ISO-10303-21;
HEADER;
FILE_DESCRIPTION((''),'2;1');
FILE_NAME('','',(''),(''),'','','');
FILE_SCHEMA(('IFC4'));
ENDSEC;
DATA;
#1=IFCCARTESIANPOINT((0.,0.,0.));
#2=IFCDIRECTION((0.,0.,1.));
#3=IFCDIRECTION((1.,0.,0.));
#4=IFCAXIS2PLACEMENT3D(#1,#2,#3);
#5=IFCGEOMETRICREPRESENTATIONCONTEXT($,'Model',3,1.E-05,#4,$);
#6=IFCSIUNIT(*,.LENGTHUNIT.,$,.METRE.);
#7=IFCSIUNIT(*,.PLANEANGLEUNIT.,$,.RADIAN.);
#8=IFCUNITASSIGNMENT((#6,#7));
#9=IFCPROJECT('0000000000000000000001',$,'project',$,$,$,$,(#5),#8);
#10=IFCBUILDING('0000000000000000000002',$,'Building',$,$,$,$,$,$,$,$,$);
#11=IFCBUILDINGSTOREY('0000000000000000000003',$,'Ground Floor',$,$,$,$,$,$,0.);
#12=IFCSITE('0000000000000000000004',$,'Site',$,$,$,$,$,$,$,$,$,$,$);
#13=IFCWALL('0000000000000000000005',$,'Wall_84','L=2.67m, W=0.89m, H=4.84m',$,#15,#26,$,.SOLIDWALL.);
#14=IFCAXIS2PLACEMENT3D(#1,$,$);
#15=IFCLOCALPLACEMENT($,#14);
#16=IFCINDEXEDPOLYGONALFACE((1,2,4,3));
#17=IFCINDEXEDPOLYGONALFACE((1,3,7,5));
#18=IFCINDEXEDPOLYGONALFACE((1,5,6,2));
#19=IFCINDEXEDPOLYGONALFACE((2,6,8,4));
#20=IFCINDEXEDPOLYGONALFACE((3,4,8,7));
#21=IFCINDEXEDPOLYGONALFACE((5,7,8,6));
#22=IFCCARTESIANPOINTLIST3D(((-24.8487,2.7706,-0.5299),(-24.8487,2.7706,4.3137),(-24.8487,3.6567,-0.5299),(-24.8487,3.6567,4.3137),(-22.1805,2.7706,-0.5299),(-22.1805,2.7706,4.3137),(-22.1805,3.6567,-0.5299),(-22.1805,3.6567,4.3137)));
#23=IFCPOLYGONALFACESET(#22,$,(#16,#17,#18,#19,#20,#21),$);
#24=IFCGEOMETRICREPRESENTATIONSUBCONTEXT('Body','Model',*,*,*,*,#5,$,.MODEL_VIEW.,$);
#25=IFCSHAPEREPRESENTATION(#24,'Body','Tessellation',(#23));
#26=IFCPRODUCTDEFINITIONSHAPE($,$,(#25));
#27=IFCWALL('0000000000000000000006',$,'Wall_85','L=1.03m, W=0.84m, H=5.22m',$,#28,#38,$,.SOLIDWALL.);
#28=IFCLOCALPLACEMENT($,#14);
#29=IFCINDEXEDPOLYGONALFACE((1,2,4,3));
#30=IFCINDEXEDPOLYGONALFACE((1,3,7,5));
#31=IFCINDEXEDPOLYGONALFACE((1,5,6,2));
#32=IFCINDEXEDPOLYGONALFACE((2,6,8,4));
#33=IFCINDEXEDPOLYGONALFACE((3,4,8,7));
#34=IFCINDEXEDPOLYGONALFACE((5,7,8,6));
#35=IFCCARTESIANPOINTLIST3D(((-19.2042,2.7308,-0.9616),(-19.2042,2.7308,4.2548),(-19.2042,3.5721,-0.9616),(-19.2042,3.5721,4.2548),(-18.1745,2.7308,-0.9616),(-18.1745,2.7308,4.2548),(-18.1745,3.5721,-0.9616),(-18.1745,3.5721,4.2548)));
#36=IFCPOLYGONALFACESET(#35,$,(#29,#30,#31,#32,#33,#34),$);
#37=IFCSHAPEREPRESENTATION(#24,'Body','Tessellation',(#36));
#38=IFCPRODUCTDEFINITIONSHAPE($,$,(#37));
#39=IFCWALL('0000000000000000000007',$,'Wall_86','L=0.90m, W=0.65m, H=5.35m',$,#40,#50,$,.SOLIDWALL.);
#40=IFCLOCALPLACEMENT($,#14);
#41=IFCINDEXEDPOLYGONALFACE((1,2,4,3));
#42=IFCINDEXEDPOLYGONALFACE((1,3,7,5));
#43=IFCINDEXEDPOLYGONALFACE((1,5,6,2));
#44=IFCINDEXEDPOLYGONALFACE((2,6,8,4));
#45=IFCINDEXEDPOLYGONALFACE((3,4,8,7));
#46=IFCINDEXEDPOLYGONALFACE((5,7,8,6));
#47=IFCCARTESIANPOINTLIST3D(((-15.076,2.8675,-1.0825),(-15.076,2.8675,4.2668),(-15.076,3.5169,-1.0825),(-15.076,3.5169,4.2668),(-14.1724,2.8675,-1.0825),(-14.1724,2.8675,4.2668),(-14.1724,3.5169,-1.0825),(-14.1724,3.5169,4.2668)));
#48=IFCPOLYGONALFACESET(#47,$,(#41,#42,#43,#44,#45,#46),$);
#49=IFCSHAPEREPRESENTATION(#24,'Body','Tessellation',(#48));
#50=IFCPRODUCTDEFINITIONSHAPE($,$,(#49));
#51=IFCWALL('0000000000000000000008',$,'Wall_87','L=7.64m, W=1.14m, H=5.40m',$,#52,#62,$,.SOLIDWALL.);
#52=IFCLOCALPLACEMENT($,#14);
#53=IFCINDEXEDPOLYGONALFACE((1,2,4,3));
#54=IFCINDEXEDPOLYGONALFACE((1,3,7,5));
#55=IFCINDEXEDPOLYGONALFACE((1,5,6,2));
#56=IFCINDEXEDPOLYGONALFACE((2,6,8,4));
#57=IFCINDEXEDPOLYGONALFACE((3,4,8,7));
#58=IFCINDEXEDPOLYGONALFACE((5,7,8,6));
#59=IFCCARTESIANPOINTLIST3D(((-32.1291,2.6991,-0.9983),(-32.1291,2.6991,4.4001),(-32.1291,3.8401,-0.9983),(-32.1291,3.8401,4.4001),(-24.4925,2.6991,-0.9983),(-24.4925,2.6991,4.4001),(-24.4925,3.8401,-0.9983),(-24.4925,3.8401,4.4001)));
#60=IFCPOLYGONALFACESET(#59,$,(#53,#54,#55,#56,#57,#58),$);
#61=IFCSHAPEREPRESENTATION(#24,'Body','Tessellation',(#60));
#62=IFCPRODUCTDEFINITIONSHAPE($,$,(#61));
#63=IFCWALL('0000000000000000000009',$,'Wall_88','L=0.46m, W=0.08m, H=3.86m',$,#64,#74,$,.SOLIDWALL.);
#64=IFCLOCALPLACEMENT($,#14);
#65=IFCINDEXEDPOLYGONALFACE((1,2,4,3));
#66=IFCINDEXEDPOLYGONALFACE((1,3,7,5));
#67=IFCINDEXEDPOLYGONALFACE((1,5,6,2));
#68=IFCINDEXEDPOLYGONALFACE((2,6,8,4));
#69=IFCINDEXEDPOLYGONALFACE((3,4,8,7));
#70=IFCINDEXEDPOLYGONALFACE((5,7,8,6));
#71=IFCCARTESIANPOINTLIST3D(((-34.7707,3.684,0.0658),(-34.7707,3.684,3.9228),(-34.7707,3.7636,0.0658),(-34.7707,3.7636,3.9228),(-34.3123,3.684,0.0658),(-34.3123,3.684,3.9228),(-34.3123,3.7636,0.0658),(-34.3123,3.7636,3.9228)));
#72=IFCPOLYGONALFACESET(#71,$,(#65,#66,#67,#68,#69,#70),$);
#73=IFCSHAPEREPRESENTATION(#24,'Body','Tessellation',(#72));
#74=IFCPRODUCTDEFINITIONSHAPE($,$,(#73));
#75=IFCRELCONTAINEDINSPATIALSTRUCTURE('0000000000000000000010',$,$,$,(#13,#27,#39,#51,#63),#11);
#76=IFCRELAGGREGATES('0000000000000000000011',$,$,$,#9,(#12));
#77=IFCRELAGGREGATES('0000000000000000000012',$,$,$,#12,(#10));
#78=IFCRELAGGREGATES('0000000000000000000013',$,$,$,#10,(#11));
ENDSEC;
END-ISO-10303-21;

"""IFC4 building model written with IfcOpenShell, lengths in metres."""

from ifc_helpers import new_model, si_unit, frame, origin_with_axes, origin_2d, context, subcontext, project, spatial, rectangle, extrude, element, save


model = new_model("IFC4")

# Units and contexts
model_context = context("Model", 3, precision=1e-05, world=origin_with_axes())
body_context = subcontext(model_context, "Body", "Model", "MODEL_VIEW")
ifc_project = project(units=[si_unit("LENGTHUNIT", "METRE"), si_unit("PLANEANGLEUNIT", "RADIAN")], contexts=[model_context])

# Site, building, storey
site = spatial("IfcSite", under=ifc_project, Name="Site")
building = spatial("IfcBuilding", under=site, Name="Building")
storey = spatial("IfcBuildingStorey", under=building, Name="Ground Floor", Elevation=0.0)

# Walls
element("IfcWall", 1, inside=storey, Name="Wall_84", Description="L=2.67m, W=0.89m, H=4.84m", PredefinedType="SOLIDWALL", context=body_context, shape_type="SweptSolid", body=[
    extrude(rectangle(XDim=2.6682, YDim=0.8861, at=origin_2d()), frame((-23.5146, 3.2136, -0.5299), z_axis=(0.0, 0.0, 1.0), x_axis=(1.0, 0.0, 0.0)), (0.0, 0.0, 1.0), 4.8436),
])
element("IfcWall", 2, inside=storey, Name="Wall_85", Description="L=1.03m, W=0.84m, H=5.22m", PredefinedType="SOLIDWALL", context=body_context, shape_type="SweptSolid", body=[
    extrude(rectangle(XDim=1.0297, YDim=0.8412, at=origin_2d()), frame((-18.6894, 3.1514, -0.9616), z_axis=(0.0, 0.0, 1.0), x_axis=(1.0, 0.0, 0.0)), (0.0, 0.0, 1.0), 5.2164),
])
element("IfcWall", 3, inside=storey, Name="Wall_86", Description="L=0.90m, W=0.65m, H=5.35m", PredefinedType="SOLIDWALL", context=body_context, shape_type="SweptSolid", body=[
    extrude(rectangle(XDim=0.9035, YDim=0.6494, at=origin_2d()), frame((-14.6242, 3.1922, -1.0825), z_axis=(0.0, 0.0, 1.0), x_axis=(1.0, 0.0, 0.0)), (0.0, 0.0, 1.0), 5.3493),
])
element("IfcWall", 4, inside=storey, Name="Wall_87", Description="L=7.64m, W=1.14m, H=5.40m", PredefinedType="SOLIDWALL", context=body_context, shape_type="SweptSolid", body=[
    extrude(rectangle(XDim=7.6367, YDim=1.1411, at=origin_2d()), frame((-28.3108, 3.2696, -0.9983), z_axis=(0.0, 0.0, 1.0), x_axis=(1.0, 0.0, 0.0)), (0.0, 0.0, 1.0), 5.3984),
])
element("IfcWall", 5, inside=storey, Name="Wall_88", Description="L=0.46m, W=0.08m, H=3.86m", PredefinedType="SOLIDWALL", context=body_context, shape_type="SweptSolid", body=[
    extrude(rectangle(XDim=0.4584, YDim=0.0796, at=origin_2d()), frame((-34.5415, 3.7238, 0.0658), z_axis=(0.0, 0.0, 1.0), x_axis=(1.0, 0.0, 0.0)), (0.0, 0.0, 1.0), 3.857),
])

save(model, "model.ifc")
